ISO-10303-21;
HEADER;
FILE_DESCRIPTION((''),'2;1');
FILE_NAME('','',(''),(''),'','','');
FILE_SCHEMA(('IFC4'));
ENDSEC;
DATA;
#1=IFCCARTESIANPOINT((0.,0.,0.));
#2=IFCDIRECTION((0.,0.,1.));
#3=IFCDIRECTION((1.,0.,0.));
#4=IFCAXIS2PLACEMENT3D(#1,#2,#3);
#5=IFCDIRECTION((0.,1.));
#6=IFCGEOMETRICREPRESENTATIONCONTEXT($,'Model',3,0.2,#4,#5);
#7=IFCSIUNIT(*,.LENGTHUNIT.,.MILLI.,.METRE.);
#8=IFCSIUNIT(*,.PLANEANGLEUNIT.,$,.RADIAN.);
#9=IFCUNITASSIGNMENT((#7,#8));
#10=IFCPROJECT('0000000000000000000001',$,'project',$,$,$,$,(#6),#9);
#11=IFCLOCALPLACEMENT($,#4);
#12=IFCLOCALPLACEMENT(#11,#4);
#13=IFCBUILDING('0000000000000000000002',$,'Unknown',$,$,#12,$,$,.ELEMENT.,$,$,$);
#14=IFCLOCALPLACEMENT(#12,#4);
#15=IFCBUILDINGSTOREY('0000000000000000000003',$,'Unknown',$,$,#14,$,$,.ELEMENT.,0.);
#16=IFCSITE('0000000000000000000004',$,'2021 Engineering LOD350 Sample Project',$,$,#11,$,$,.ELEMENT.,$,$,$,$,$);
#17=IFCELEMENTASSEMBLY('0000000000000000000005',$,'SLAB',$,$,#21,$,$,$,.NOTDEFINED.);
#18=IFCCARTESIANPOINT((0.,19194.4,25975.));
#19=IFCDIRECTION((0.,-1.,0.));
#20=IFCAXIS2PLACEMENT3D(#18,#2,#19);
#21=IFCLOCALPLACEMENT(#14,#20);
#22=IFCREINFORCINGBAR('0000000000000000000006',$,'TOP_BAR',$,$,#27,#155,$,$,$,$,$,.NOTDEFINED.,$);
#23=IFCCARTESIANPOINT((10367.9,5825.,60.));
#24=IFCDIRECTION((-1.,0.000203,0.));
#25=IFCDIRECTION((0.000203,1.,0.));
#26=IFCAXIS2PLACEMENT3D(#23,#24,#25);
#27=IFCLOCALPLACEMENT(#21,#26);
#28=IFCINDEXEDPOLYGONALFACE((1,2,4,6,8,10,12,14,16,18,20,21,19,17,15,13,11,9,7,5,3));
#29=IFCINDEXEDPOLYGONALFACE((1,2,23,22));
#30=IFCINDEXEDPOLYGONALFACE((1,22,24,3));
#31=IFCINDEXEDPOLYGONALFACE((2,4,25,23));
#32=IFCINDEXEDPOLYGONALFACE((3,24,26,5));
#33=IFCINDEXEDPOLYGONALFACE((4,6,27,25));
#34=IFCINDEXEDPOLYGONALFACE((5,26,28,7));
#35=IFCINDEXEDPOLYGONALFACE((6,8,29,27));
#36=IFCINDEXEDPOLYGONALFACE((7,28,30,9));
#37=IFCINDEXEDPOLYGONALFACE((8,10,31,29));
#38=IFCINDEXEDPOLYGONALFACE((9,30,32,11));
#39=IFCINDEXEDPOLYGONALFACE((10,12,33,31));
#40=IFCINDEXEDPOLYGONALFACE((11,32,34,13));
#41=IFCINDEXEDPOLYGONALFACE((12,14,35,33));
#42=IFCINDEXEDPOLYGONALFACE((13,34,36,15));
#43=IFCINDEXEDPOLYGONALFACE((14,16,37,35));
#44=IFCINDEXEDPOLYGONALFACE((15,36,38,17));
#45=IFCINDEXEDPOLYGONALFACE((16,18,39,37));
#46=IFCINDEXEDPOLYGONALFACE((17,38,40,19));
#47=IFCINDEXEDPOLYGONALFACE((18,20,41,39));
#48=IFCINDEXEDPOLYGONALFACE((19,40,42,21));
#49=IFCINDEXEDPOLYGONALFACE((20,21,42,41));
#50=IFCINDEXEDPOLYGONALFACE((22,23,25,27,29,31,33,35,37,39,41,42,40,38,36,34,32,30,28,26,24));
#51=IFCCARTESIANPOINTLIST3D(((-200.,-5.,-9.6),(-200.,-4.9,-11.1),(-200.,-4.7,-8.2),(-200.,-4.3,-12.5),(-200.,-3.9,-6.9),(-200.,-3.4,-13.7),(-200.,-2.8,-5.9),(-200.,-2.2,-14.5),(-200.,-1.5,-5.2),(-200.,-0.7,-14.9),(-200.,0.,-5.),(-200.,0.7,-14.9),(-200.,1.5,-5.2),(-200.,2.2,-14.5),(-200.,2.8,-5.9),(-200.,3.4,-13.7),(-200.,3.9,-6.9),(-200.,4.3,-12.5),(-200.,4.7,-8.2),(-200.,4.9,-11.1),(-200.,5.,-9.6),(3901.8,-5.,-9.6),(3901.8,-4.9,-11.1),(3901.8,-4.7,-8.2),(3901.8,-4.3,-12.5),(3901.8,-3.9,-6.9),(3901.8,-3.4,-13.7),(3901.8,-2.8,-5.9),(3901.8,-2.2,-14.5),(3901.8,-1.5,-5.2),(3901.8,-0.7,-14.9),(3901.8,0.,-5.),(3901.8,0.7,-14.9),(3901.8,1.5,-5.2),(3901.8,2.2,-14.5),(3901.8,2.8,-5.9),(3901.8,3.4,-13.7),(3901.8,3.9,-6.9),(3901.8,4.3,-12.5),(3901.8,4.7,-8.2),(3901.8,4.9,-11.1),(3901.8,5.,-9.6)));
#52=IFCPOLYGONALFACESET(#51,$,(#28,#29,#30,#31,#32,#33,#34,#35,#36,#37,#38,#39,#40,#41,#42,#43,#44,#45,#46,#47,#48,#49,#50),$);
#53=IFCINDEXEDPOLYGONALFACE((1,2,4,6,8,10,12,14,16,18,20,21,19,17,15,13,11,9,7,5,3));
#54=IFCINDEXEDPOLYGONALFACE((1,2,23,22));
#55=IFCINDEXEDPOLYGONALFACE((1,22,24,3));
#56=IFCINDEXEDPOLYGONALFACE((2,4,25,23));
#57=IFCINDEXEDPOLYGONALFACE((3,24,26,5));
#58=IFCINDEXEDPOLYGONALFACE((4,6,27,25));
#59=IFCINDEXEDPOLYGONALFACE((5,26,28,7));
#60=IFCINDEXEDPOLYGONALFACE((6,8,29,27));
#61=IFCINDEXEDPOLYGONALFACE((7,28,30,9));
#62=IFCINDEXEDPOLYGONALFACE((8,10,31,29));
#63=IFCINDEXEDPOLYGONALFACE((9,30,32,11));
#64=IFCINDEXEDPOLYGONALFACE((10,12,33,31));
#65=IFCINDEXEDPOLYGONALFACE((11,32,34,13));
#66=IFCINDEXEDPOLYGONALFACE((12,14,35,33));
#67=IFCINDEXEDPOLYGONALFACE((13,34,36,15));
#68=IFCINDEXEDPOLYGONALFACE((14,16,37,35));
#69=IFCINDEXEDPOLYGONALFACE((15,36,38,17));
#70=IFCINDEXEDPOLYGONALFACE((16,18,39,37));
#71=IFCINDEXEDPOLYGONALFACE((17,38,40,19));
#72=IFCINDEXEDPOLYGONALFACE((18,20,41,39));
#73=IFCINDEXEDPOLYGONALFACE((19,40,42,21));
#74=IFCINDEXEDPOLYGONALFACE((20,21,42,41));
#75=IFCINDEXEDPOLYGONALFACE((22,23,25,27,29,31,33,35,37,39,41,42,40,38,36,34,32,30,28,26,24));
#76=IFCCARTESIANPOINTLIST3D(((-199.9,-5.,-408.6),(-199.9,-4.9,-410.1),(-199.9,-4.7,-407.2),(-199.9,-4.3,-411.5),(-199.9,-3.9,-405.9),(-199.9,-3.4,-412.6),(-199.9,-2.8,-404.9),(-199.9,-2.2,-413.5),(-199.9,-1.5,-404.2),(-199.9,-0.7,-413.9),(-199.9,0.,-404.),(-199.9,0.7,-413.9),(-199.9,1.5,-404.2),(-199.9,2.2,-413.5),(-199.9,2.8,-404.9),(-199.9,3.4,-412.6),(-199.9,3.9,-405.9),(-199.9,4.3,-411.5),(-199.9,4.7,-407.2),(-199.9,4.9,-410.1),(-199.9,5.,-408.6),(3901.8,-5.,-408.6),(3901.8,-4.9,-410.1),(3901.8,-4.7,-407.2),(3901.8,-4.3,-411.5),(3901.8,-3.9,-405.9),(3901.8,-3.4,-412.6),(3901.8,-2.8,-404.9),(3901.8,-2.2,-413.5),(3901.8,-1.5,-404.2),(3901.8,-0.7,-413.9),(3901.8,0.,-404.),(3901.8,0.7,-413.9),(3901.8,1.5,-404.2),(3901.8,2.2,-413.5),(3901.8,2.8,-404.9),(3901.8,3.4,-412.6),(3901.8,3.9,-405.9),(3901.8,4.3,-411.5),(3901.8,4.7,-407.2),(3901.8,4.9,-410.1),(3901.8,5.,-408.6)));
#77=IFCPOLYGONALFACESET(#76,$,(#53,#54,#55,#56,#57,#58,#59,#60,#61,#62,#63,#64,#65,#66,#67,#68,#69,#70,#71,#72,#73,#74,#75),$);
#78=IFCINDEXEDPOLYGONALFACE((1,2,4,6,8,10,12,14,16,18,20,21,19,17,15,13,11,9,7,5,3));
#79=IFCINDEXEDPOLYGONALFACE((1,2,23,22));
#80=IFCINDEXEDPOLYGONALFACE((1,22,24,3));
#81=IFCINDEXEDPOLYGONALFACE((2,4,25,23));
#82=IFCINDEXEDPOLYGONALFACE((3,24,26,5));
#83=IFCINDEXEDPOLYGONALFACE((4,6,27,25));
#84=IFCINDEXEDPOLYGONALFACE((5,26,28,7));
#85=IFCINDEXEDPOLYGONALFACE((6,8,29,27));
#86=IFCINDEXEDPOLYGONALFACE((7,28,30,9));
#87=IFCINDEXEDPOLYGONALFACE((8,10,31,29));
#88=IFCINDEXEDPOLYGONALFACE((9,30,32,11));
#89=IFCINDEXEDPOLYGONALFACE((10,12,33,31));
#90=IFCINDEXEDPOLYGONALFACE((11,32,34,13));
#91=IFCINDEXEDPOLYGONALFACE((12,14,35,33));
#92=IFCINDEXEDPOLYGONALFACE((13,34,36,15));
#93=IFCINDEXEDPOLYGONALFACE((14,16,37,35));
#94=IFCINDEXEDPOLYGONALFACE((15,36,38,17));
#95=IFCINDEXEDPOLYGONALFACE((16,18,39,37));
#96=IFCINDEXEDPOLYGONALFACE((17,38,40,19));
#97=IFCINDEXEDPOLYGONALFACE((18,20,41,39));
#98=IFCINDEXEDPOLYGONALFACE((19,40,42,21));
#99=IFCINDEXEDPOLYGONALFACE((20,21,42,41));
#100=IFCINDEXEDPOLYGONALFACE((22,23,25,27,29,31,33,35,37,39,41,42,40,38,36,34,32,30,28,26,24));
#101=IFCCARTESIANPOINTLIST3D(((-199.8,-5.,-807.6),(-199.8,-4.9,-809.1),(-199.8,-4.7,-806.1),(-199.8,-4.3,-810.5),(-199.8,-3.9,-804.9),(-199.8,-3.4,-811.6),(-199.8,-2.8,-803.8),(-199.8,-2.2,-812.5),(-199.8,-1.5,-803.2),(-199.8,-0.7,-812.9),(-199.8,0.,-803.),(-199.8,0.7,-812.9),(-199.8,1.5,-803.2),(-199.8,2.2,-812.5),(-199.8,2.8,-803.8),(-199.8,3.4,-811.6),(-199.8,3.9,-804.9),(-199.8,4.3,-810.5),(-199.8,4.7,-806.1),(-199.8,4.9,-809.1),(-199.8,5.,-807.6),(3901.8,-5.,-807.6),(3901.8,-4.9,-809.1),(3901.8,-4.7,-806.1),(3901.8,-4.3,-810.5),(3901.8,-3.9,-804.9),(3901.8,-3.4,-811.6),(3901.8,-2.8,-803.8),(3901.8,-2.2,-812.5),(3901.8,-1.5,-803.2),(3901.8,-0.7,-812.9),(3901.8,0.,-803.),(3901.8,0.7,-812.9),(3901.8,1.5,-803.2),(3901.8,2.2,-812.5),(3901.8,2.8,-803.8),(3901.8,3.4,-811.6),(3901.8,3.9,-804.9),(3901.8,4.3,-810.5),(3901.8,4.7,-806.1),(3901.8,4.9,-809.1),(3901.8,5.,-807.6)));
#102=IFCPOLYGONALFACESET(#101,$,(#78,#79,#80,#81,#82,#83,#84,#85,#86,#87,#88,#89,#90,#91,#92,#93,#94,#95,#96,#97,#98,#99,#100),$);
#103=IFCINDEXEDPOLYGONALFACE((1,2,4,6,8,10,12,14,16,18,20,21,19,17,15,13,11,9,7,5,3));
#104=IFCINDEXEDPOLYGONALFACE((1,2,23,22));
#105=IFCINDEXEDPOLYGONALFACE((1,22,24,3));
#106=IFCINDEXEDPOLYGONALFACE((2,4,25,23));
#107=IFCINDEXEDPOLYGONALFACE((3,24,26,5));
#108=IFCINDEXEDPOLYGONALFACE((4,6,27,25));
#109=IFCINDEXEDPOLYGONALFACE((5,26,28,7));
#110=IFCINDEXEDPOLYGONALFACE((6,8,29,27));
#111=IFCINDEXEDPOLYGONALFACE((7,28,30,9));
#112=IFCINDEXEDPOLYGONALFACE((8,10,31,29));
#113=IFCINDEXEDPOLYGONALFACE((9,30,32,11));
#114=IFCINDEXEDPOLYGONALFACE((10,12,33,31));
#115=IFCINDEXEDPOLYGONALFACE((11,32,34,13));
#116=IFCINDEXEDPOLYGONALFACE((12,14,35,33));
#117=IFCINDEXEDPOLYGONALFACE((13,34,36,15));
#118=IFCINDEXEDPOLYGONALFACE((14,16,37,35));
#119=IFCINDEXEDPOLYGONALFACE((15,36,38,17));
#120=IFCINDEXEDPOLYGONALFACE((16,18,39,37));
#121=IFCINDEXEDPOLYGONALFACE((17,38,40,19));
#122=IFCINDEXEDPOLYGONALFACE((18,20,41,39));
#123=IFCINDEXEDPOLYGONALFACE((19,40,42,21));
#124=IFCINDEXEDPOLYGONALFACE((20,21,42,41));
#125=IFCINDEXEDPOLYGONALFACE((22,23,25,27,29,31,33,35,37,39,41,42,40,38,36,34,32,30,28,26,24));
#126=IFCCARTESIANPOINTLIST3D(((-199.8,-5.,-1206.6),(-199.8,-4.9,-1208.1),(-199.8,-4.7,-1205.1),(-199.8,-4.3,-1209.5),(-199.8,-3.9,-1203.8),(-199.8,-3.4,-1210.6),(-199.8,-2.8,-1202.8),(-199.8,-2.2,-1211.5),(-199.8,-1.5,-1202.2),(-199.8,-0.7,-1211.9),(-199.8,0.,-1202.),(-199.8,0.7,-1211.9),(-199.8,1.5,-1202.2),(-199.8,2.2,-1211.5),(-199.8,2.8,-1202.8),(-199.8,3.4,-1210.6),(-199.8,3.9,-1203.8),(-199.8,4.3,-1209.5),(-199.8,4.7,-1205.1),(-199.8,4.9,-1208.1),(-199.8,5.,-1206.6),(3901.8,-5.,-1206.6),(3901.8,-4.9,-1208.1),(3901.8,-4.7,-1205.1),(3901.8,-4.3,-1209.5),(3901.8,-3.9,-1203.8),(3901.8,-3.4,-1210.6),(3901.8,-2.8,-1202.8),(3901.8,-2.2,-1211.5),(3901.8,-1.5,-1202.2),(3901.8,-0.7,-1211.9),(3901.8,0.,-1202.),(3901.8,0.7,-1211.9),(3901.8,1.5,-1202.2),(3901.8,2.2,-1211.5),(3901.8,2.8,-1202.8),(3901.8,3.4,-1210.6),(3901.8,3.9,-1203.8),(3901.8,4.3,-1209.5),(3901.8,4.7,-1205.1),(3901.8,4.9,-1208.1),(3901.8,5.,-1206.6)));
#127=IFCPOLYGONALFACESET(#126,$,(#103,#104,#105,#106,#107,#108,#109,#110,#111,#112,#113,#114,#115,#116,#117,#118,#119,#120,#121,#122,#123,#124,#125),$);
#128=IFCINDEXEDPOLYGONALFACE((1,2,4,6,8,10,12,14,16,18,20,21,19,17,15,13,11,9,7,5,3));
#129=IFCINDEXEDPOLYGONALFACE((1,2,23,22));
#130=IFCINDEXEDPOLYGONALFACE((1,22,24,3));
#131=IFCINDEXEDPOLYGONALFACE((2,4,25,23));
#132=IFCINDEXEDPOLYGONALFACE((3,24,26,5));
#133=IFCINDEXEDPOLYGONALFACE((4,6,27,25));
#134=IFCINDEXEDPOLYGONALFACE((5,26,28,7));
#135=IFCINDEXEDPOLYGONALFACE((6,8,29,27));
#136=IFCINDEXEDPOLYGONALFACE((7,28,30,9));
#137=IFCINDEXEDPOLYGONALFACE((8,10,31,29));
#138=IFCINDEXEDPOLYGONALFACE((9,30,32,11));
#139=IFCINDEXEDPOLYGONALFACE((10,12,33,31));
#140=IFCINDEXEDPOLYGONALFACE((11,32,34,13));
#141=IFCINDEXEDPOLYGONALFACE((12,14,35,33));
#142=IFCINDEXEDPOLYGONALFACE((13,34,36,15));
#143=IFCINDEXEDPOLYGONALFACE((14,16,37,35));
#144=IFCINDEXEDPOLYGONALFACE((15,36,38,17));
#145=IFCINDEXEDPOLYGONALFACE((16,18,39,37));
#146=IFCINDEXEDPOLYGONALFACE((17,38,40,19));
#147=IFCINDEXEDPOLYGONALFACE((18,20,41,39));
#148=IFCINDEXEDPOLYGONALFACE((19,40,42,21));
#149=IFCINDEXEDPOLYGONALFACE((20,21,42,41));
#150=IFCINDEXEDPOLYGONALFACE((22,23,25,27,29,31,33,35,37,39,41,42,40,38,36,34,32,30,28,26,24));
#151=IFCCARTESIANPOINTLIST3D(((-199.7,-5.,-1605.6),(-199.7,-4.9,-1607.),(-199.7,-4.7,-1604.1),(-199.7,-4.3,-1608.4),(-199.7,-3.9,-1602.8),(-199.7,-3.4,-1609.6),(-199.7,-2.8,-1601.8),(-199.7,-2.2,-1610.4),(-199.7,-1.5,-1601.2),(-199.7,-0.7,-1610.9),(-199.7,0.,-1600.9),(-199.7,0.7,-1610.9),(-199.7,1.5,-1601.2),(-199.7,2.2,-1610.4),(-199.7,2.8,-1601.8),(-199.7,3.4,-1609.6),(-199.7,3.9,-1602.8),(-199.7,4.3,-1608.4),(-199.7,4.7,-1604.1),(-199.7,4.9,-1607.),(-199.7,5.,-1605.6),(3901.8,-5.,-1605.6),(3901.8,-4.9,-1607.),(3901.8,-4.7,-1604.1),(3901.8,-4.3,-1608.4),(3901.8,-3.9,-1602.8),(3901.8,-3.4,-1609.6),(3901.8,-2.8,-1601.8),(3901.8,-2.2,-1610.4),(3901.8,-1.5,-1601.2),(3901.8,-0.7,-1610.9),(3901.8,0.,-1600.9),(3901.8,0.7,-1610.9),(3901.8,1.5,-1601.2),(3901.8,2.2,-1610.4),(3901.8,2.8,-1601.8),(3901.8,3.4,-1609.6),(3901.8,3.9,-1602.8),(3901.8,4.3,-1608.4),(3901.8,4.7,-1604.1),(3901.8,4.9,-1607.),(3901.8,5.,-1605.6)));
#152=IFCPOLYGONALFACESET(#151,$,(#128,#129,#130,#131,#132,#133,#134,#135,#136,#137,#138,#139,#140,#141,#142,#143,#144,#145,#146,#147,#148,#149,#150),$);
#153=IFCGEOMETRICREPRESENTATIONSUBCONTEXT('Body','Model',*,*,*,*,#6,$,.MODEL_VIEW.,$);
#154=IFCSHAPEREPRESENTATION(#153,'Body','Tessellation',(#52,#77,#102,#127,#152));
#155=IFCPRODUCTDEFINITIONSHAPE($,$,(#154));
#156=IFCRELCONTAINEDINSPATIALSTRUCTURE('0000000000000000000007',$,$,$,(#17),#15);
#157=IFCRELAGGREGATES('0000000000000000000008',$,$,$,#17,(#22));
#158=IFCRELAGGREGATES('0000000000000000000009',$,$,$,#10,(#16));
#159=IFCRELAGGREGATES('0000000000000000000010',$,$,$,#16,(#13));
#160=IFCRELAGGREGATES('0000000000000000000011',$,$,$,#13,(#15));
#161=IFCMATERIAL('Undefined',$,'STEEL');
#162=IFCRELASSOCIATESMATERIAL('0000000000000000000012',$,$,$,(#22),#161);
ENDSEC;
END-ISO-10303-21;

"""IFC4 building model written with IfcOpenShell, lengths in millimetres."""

from ifc_helpers import new_model, entity, si_unit, direction, frame, origin_with_axes, place, context, subcontext, project, spatial, material, element, aggregate, save


model = new_model("IFC4")

# Units and contexts
model_context = context("Model", 3, precision=0.2, world=origin_with_axes(), true_north=direction((0.0, 1.0)))
body_context = subcontext(model_context, "Body", "Model", "MODEL_VIEW")
ifc_project = project(units=[si_unit("LENGTHUNIT", "METRE", prefix="MILLI"), si_unit("PLANEANGLEUNIT", "RADIAN")], contexts=[model_context])

# Site, building, storey
site_placement = place(None, origin_with_axes())
site = spatial("IfcSite", under=ifc_project, at=site_placement, Name="2021 Engineering LOD350 Sample Project", CompositionType="ELEMENT")
building_placement = place(site_placement, origin_with_axes())
building = spatial("IfcBuilding", under=site, at=building_placement, Name="Unknown", CompositionType="ELEMENT")
storey_placement = place(building_placement, origin_with_axes())
storey = spatial("IfcBuildingStorey", under=building, at=storey_placement, Name="Unknown", CompositionType="ELEMENT", Elevation=0.0)

# Element assembly
assembly_1_placement = place(storey_placement, frame((0.0, 19194.4, 25975.0), z_axis=(0.0, 0.0, 1.0), x_axis=(0.0, -1.0, 0.0)))
assembly_1 = element("IfcElementAssembly", 1, at=assembly_1_placement, inside=storey, Name="SLAB", PredefinedType="NOTDEFINED")
ifc_material_1 = material(Name="Undefined", Category="STEEL")

# Reinforcing bar
reinforcing_bar_1_placement = place(assembly_1_placement, frame((10367.9, 5825.0, 60.0), z_axis=(-1.0, 0.000203, 0.0), x_axis=(0.000203, 1.0, 0.0)))
reinforcing_bar_1 = element("IfcReinforcingBar", 2, at=reinforcing_bar_1_placement, material=ifc_material_1, Name="TOP_BAR", PredefinedType="NOTDEFINED", context=body_context, shape_type="AdvancedSweptSolid", body=[
    entity("IfcSweptDiskSolid", entity("IfcIndexedPolyCurve", entity("IfcCartesianPointList3D", [[-200.0, 0.0, -10.0], [3901.8, 0.0, -10.0]]), [entity("IfcLineIndex", [1, 2])]), 5.0),
    entity("IfcSweptDiskSolid", entity("IfcIndexedPolyCurve", entity("IfcCartesianPointList3D", [[-199.9, 0.0, -409.0], [3901.8, 0.0, -409.0]]), [entity("IfcLineIndex", [1, 2])]), 5.0),
    entity("IfcSweptDiskSolid", entity("IfcIndexedPolyCurve", entity("IfcCartesianPointList3D", [[-199.8, 0.0, -808.0], [3901.8, 0.0, -808.0]]), [entity("IfcLineIndex", [1, 2])]), 5.0),
    entity("IfcSweptDiskSolid", entity("IfcIndexedPolyCurve", entity("IfcCartesianPointList3D", [[-199.8, 0.0, -1207.0], [3901.8, 0.0, -1207.0]]), [entity("IfcLineIndex", [1, 2])]), 5.0),
    entity("IfcSweptDiskSolid", entity("IfcIndexedPolyCurve", entity("IfcCartesianPointList3D", [[-199.7, 0.0, -1605.9], [3901.8, 0.0, -1605.9]]), [entity("IfcLineIndex", [1, 2])]), 5.0),
])
aggregate(assembly_1, [reinforcing_bar_1])

save(model, "model.ifc")
